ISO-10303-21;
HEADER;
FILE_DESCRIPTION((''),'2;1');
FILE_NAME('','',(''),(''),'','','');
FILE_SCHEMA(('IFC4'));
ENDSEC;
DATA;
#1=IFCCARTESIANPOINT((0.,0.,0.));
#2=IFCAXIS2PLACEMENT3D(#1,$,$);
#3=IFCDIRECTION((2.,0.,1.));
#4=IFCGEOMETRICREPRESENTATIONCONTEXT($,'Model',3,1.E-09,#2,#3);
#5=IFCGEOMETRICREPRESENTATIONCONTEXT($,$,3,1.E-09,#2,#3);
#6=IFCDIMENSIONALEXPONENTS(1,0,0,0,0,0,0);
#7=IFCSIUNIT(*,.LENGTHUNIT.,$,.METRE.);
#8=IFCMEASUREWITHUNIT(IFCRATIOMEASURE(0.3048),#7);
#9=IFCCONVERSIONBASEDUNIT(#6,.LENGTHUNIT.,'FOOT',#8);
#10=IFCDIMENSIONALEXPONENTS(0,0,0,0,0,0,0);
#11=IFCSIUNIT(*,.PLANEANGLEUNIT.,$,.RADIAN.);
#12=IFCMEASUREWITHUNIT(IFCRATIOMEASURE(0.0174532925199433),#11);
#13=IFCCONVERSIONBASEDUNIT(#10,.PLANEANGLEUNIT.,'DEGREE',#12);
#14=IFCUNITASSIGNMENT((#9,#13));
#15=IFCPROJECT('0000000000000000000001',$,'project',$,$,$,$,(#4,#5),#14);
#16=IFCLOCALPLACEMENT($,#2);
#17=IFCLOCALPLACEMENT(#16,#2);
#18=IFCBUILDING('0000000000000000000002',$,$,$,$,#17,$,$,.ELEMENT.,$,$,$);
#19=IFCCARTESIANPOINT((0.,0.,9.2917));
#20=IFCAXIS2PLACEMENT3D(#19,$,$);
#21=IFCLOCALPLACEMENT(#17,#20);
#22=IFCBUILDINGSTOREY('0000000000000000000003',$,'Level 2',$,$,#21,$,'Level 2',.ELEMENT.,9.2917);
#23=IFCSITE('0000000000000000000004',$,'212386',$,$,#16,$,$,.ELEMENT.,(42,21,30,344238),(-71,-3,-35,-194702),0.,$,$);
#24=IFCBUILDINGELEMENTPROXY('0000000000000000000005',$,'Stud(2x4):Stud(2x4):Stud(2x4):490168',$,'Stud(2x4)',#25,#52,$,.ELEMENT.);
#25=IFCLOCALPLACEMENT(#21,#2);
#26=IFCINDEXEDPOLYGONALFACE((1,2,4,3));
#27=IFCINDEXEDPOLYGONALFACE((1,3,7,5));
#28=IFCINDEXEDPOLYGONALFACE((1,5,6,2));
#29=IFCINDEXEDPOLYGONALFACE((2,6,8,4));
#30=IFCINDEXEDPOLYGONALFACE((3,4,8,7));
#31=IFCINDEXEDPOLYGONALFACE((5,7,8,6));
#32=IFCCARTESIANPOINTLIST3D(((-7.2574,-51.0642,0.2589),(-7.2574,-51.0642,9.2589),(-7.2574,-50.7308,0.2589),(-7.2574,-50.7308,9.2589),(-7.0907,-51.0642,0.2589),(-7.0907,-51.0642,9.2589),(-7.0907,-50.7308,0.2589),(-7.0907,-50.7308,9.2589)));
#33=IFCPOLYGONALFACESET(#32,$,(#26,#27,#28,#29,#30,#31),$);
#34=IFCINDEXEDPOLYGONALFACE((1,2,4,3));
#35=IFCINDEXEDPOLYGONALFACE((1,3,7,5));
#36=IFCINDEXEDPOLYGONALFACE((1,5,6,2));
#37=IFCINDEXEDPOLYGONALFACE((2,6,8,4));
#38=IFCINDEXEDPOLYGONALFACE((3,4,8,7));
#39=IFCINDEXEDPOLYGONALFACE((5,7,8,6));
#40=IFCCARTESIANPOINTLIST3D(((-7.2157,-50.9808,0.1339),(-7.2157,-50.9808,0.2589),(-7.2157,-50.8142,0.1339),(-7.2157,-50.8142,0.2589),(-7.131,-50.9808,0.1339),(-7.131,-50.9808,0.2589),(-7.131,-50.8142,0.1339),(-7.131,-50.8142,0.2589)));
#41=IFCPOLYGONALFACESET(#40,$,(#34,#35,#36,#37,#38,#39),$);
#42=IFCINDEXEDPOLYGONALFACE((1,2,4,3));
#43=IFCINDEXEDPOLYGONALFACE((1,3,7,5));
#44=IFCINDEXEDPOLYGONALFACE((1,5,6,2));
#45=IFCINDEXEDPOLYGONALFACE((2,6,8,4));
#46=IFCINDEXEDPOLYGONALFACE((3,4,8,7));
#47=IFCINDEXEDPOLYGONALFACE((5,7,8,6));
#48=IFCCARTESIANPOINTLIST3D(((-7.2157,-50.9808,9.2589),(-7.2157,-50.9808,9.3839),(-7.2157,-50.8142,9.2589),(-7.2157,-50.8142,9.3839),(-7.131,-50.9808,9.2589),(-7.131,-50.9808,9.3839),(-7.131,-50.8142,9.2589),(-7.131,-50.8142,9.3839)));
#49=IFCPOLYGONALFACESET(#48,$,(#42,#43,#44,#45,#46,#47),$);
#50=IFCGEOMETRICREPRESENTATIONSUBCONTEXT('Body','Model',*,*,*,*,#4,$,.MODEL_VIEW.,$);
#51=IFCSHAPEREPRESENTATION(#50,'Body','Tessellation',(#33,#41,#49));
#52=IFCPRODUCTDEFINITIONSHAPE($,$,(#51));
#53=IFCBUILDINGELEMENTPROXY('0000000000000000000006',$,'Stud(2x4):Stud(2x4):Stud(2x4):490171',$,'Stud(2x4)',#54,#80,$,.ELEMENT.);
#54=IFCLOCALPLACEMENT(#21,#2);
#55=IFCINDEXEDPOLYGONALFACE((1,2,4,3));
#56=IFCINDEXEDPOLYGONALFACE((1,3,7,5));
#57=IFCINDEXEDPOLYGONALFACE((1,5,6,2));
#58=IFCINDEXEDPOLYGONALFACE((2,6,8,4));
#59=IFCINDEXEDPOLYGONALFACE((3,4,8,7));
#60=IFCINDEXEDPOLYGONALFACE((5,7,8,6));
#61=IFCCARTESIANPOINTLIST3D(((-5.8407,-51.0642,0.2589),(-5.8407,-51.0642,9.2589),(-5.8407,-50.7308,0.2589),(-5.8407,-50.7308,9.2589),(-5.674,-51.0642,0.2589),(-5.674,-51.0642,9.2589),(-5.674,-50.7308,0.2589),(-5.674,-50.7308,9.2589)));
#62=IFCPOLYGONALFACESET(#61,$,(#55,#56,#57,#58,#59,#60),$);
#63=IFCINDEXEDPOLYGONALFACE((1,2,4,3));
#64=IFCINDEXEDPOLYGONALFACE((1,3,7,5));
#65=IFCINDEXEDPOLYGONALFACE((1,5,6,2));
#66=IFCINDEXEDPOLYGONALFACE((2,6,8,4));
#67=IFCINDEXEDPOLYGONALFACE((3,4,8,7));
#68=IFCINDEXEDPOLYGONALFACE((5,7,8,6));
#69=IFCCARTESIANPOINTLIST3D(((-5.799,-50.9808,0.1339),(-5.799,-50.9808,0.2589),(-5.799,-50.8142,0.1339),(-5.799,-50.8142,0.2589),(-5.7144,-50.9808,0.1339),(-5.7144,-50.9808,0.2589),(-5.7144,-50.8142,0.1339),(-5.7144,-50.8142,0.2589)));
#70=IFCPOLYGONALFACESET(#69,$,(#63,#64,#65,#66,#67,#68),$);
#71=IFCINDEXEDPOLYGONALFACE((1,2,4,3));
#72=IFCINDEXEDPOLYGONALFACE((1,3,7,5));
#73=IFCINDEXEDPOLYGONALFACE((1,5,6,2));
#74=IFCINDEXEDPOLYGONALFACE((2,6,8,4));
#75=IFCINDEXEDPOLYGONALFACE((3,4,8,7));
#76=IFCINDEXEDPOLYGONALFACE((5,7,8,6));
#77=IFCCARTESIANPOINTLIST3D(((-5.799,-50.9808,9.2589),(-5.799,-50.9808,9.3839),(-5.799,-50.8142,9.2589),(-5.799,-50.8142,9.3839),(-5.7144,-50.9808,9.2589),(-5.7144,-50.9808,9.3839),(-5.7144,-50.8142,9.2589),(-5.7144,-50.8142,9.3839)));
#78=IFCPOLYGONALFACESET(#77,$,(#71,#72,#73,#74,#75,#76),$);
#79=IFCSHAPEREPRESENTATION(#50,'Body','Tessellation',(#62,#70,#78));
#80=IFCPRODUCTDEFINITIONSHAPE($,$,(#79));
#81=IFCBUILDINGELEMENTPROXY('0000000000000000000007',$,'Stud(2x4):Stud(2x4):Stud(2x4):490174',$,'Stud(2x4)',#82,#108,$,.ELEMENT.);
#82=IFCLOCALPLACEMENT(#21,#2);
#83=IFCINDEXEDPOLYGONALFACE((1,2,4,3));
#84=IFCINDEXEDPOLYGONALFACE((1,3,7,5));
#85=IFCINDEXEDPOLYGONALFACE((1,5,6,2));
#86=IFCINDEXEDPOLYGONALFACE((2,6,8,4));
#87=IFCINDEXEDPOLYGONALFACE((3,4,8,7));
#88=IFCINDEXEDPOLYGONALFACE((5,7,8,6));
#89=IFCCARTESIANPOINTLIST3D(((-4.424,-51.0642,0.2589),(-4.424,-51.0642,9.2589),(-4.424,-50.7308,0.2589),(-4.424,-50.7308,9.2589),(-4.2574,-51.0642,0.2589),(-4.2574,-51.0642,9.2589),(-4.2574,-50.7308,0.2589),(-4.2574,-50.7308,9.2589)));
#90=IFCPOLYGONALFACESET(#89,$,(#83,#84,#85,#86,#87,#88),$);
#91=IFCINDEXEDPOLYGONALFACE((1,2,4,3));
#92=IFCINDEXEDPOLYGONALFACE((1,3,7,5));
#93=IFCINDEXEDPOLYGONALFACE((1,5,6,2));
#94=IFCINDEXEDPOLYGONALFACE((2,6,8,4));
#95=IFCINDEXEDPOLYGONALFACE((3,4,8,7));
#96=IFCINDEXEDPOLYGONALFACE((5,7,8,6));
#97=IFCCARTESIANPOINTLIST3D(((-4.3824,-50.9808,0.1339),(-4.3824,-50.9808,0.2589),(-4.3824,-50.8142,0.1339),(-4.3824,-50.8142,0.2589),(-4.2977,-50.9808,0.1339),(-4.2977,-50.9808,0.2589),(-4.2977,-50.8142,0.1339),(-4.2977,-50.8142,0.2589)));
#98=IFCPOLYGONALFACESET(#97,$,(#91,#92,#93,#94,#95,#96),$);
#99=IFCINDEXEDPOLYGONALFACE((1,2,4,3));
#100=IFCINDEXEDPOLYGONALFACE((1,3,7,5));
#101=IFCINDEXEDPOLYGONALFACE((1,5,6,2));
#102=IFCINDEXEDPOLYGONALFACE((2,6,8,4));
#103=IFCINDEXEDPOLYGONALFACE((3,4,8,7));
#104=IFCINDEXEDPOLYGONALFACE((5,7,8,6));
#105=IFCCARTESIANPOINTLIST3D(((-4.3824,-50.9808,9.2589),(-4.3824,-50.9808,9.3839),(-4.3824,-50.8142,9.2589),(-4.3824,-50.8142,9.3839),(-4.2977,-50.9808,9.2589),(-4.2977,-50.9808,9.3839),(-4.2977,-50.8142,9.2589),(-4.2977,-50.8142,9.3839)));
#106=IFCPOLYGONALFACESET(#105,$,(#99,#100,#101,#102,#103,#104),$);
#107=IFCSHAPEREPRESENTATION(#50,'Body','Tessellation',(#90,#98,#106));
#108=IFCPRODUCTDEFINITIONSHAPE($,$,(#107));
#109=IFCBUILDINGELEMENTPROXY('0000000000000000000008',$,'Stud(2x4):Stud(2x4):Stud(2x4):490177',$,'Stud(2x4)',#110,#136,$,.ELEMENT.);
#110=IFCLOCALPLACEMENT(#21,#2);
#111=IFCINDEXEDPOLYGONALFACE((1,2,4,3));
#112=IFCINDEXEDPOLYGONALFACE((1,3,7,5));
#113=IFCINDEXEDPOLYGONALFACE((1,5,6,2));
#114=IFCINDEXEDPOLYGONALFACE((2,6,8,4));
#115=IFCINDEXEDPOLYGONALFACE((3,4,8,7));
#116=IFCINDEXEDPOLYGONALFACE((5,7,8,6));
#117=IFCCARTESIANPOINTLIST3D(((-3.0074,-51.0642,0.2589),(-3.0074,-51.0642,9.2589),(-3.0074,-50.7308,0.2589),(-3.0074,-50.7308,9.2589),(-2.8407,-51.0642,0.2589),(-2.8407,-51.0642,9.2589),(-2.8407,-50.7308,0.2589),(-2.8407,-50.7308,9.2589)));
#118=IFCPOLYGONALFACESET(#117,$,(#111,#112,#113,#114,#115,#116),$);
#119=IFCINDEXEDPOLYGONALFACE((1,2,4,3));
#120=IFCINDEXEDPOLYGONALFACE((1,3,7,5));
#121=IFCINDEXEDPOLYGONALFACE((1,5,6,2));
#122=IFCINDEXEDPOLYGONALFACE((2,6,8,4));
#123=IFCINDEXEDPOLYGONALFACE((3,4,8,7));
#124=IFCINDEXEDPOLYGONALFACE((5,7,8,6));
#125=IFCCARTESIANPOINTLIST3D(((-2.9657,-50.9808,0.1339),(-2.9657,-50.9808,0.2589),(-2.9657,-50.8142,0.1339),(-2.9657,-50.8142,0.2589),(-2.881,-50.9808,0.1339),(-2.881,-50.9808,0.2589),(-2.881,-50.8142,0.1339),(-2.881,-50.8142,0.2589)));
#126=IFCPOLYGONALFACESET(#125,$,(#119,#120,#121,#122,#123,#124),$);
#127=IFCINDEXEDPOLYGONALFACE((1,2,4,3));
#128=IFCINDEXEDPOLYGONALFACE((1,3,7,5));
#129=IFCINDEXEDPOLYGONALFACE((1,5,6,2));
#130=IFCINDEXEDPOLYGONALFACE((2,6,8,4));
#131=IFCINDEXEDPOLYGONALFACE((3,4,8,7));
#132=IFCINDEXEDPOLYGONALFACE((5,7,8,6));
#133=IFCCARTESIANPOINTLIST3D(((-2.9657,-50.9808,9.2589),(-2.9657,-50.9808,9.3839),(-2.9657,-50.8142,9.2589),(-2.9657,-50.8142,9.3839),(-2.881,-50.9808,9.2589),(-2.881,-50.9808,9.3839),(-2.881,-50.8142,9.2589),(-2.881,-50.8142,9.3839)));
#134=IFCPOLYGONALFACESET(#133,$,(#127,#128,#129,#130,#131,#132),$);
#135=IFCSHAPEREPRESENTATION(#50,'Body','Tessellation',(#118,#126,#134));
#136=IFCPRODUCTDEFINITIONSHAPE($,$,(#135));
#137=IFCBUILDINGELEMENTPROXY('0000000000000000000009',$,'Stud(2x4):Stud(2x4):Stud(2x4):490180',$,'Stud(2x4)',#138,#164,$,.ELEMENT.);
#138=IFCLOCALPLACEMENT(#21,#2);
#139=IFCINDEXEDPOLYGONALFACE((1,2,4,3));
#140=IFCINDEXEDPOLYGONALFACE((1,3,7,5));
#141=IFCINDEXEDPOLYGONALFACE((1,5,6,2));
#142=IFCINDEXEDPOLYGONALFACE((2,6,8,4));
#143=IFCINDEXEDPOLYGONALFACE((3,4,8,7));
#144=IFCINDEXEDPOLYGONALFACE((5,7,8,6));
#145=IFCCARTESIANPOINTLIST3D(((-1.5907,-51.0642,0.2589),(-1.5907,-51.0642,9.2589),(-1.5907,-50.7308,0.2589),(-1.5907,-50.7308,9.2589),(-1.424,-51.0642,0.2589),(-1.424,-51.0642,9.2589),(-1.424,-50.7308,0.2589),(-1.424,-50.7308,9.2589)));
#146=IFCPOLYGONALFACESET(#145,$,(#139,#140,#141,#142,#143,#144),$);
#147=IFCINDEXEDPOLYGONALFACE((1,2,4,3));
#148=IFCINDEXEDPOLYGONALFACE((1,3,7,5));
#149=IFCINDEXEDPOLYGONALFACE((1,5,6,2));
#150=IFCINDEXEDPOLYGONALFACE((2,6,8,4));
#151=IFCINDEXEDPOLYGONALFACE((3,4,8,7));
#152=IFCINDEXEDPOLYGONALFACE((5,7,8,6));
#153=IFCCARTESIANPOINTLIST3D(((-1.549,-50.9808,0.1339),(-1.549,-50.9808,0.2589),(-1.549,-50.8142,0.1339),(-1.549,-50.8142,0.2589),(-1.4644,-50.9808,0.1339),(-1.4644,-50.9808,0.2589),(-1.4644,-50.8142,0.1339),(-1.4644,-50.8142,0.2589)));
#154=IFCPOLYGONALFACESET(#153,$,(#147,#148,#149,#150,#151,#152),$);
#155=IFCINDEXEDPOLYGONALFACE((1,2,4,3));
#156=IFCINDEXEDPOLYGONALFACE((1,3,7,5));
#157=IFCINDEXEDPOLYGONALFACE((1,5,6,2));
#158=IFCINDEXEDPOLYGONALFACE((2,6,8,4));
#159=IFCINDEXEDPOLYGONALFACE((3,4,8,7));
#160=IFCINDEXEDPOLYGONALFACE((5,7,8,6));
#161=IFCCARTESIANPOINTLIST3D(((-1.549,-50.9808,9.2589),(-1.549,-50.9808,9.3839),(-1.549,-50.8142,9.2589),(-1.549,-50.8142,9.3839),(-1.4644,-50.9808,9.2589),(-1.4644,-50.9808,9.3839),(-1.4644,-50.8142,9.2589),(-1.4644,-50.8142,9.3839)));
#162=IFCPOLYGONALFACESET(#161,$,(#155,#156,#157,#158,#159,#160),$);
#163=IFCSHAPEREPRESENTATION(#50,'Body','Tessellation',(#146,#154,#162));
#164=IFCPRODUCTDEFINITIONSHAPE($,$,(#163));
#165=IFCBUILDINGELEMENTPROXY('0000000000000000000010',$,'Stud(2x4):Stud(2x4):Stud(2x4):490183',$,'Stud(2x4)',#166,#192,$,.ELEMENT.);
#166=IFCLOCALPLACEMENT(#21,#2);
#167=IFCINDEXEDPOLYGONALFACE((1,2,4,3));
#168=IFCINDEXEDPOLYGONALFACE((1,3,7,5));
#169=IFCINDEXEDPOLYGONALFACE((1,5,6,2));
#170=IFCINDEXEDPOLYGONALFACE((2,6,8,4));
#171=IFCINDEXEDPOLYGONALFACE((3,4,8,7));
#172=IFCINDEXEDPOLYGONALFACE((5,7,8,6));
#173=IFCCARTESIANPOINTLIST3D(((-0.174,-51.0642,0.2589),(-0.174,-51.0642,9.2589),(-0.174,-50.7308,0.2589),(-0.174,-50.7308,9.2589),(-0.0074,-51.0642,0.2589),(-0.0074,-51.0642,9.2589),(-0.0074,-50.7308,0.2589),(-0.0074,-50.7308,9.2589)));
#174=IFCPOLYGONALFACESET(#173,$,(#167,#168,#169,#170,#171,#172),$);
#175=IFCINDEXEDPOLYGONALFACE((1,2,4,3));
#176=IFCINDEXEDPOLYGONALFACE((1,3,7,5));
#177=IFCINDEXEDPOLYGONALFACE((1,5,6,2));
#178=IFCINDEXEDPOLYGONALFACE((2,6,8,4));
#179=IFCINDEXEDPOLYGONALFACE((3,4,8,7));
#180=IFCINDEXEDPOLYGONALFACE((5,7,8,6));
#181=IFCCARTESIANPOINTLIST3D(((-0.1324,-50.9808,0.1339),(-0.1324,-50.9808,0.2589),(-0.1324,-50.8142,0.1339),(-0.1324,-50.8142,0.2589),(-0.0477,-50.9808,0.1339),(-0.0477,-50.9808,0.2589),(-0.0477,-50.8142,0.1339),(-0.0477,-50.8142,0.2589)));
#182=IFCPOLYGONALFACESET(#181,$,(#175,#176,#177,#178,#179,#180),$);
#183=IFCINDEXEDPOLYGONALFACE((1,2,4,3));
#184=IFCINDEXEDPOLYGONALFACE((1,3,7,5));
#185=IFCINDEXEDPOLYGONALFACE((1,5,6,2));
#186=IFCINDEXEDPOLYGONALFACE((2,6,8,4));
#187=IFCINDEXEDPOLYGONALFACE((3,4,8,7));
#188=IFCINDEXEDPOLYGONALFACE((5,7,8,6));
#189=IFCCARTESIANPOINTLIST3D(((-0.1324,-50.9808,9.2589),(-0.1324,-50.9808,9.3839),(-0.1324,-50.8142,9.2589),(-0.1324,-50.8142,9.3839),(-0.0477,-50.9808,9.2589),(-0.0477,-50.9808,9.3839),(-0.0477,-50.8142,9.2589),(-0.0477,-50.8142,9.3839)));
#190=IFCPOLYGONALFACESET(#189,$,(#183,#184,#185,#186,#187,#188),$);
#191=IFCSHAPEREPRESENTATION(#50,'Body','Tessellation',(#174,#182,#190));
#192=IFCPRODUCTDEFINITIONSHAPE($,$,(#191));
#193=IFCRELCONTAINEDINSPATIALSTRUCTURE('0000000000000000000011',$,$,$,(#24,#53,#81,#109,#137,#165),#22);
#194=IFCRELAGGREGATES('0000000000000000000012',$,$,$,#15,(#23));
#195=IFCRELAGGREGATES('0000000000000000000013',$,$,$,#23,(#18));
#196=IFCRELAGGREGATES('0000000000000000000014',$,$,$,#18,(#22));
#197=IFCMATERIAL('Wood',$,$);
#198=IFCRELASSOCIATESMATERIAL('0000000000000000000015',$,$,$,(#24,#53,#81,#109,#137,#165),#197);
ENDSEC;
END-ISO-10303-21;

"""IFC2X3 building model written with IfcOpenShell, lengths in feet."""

from ifc_helpers import new_model, entity, si_unit, converted_unit, direction, frame, frame_2d, origin, place, context, subcontext, project, spatial, rectangle, extrude, source, transform, mapped, material, element, save


model = new_model("IFC2X3")

# Units and contexts
model_context = context("Model", 3, precision=1e-09, world=origin(), true_north=direction((2.0, 0.0, 1.0)))
context_of_model = context(None, 3, precision=1e-09, world=origin(), true_north=direction((2.0, 0.0, 1.0)))
body_context = subcontext(model_context, "Body", "Model", "MODEL_VIEW")
ifc_project = project(units=[converted_unit("LENGTHUNIT", "FOOT", entity("IfcRatioMeasure", 0.3048), si_unit("LENGTHUNIT", "METRE"), dimensions=[1, 0, 0, 0, 0, 0, 0]), converted_unit("PLANEANGLEUNIT", "DEGREE", entity("IfcRatioMeasure", 0.0174532925199433), si_unit("PLANEANGLEUNIT", "RADIAN"), dimensions=[0, 0, 0, 0, 0, 0, 0])], contexts=[model_context, context_of_model])

# Site, building, storey
site_placement = place(None, origin())
site = spatial("IfcSite", under=ifc_project, at=site_placement, Name="212386", CompositionType="ELEMENT", RefLatitude=(42, 21, 30, 344238), RefLongitude=(-71, -3, -35, -194702), RefElevation=0.0)
building_placement = place(site_placement, origin())
building = spatial("IfcBuilding", under=site, at=building_placement, CompositionType="ELEMENT")
storey_placement = place(building_placement, frame((0.0, 0.0, 9.2917)))
storey = spatial("IfcBuildingStorey", under=building, at=storey_placement, Name="Level 2", LongName="Level 2", CompositionType="ELEMENT", Elevation=9.2917)

# Building element proxies
ifc_material = material(Name="Wood")
shared_shape_1 = source(origin(), body_context, "Body", "SweptSolid", [
    extrude(rectangle(XDim=0.3333, YDim=0.1667, at=frame_2d((0.0, 0.0), x_axis=(1.0, 0.0))), frame((-7.174, -50.8975, 9.5506), z_axis=(0.0, 0.0, 1.0), x_axis=(0.0, -1.0, 0.0)), (0.0, 0.0, 1.0), 9.0),
    extrude(rectangle(XDim=0.1667, YDim=0.0847, at=frame_2d((0.0, 0.0), x_axis=(1.0, 0.0))), frame((-7.1734, -50.8975, 9.4256), z_axis=(0.0, 0.0, 1.0), x_axis=(0.0, -1.0, 0.0)), (0.0, 0.0, 1.0), 0.125),
    extrude(rectangle(XDim=0.0847, YDim=0.1667, at=frame_2d((0.0, 0.0), x_axis=(1.0, 0.0))), frame((-7.1734, -50.8975, 18.5506)), (0.0, 0.0, 1.0), 0.125),
])
proxy_1_placement = place(storey_placement, frame((0.0, 0.0, -9.2917)))
element("IfcBuildingElementProxy", 1, at=proxy_1_placement, inside=storey, material=ifc_material, Name="Stud(2x4):Stud(2x4):Stud(2x4):490168", ObjectType="Stud(2x4)", CompositionType="ELEMENT", context=body_context, shape_type="MappedRepresentation", body=[
    mapped(shared_shape_1, transform((0.0, 0.0, 0.0), scale=1.0)),
])
shared_shape_2 = source(origin(), body_context, "Body", "SweptSolid", [
    extrude(rectangle(XDim=0.3333, YDim=0.1667, at=frame_2d((0.0, 0.0), x_axis=(1.0, 0.0))), frame((-5.7574, -50.8975, 9.5506), z_axis=(0.0, 0.0, 1.0), x_axis=(0.0, -1.0, 0.0)), (0.0, 0.0, 1.0), 9.0),
    extrude(rectangle(XDim=0.1667, YDim=0.0847, at=frame_2d((0.0, 0.0), x_axis=(1.0, 0.0))), frame((-5.7567, -50.8975, 9.4256), z_axis=(0.0, 0.0, 1.0), x_axis=(0.0, -1.0, 0.0)), (0.0, 0.0, 1.0), 0.125),
    extrude(rectangle(XDim=0.0847, YDim=0.1667, at=frame_2d((0.0, 0.0), x_axis=(1.0, 0.0))), frame((-5.7567, -50.8975, 18.5506)), (0.0, 0.0, 1.0), 0.125),
])
proxy_2_placement = place(storey_placement, frame((0.0, 0.0, -9.2917)))
element("IfcBuildingElementProxy", 2, at=proxy_2_placement, inside=storey, material=ifc_material, Name="Stud(2x4):Stud(2x4):Stud(2x4):490171", ObjectType="Stud(2x4)", CompositionType="ELEMENT", context=body_context, shape_type="MappedRepresentation", body=[
    mapped(shared_shape_2, transform((0.0, 0.0, 0.0), scale=1.0)),
])
shared_shape_3 = source(origin(), body_context, "Body", "SweptSolid", [
    extrude(rectangle(XDim=0.3333, YDim=0.1667, at=frame_2d((0.0, 0.0), x_axis=(1.0, 0.0))), frame((-4.3407, -50.8975, 9.5506), z_axis=(0.0, 0.0, 1.0), x_axis=(0.0, -1.0, 0.0)), (0.0, 0.0, 1.0), 9.0),
    extrude(rectangle(XDim=0.1667, YDim=0.0847, at=frame_2d((0.0, 0.0), x_axis=(1.0, 0.0))), frame((-4.34, -50.8975, 9.4256), z_axis=(0.0, 0.0, 1.0), x_axis=(0.0, -1.0, 0.0)), (0.0, 0.0, 1.0), 0.125),
    extrude(rectangle(XDim=0.0847, YDim=0.1667, at=frame_2d((0.0, 0.0), x_axis=(1.0, 0.0))), frame((-4.34, -50.8975, 18.5506)), (0.0, 0.0, 1.0), 0.125),
])
proxy_3_placement = place(storey_placement, frame((0.0, 0.0, -9.2917)))
element("IfcBuildingElementProxy", 3, at=proxy_3_placement, inside=storey, material=ifc_material, Name="Stud(2x4):Stud(2x4):Stud(2x4):490174", ObjectType="Stud(2x4)", CompositionType="ELEMENT", context=body_context, shape_type="MappedRepresentation", body=[
    mapped(shared_shape_3, transform((0.0, 0.0, 0.0), scale=1.0)),
])
shared_shape_4 = source(origin(), body_context, "Body", "SweptSolid", [
    extrude(rectangle(XDim=0.3333, YDim=0.1667, at=frame_2d((0.0, 0.0), x_axis=(1.0, 0.0))), frame((-2.924, -50.8975, 9.5506), z_axis=(0.0, 0.0, 1.0), x_axis=(0.0, -1.0, 0.0)), (0.0, 0.0, 1.0), 9.0),
    extrude(rectangle(XDim=0.1667, YDim=0.0847, at=frame_2d((0.0, 0.0), x_axis=(1.0, 0.0))), frame((-2.9234, -50.8975, 9.4256), z_axis=(0.0, 0.0, 1.0), x_axis=(0.0, -1.0, 0.0)), (0.0, 0.0, 1.0), 0.125),
    extrude(rectangle(XDim=0.0847, YDim=0.1667, at=frame_2d((0.0, 0.0), x_axis=(1.0, 0.0))), frame((-2.9234, -50.8975, 18.5506)), (0.0, 0.0, 1.0), 0.125),
])
proxy_4_placement = place(storey_placement, frame((0.0, 0.0, -9.2917)))
element("IfcBuildingElementProxy", 4, at=proxy_4_placement, inside=storey, material=ifc_material, Name="Stud(2x4):Stud(2x4):Stud(2x4):490177", ObjectType="Stud(2x4)", CompositionType="ELEMENT", context=body_context, shape_type="MappedRepresentation", body=[
    mapped(shared_shape_4, transform((0.0, 0.0, 0.0), scale=1.0)),
])
shared_shape_5 = source(origin(), body_context, "Body", "SweptSolid", [
    extrude(rectangle(XDim=0.3333, YDim=0.1667, at=frame_2d((0.0, 0.0), x_axis=(1.0, 0.0))), frame((-1.5074, -50.8975, 9.5506), z_axis=(0.0, 0.0, 1.0), x_axis=(0.0, -1.0, 0.0)), (0.0, 0.0, 1.0), 9.0),
    extrude(rectangle(XDim=0.1667, YDim=0.0847, at=frame_2d((0.0, 0.0), x_axis=(1.0, 0.0))), frame((-1.5067, -50.8975, 9.4256), z_axis=(0.0, 0.0, 1.0), x_axis=(0.0, -1.0, 0.0)), (0.0, 0.0, 1.0), 0.125),
    extrude(rectangle(XDim=0.0847, YDim=0.1667, at=frame_2d((0.0, 0.0), x_axis=(1.0, 0.0))), frame((-1.5067, -50.8975, 18.5506)), (0.0, 0.0, 1.0), 0.125),
])
proxy_5_placement = place(storey_placement, frame((0.0, 0.0, -9.2917)))
element("IfcBuildingElementProxy", 5, at=proxy_5_placement, inside=storey, material=ifc_material, Name="Stud(2x4):Stud(2x4):Stud(2x4):490180", ObjectType="Stud(2x4)", CompositionType="ELEMENT", context=body_context, shape_type="MappedRepresentation", body=[
    mapped(shared_shape_5, transform((0.0, 0.0, 0.0), scale=1.0)),
])
shared_shape_6 = source(origin(), body_context, "Body", "SweptSolid", [
    extrude(rectangle(XDim=0.3333, YDim=0.1667, at=frame_2d((0.0, 0.0), x_axis=(1.0, 0.0))), frame((-0.0907, -50.8975, 9.5506), z_axis=(0.0, 0.0, 1.0), x_axis=(0.0, -1.0, 0.0)), (0.0, 0.0, 1.0), 9.0),
    extrude(rectangle(XDim=0.1667, YDim=0.0847, at=frame_2d((0.0, 0.0), x_axis=(1.0, 0.0))), frame((-0.09, -50.8975, 9.4256), z_axis=(0.0, 0.0, 1.0), x_axis=(0.0, -1.0, 0.0)), (0.0, 0.0, 1.0), 0.125),
    extrude(rectangle(XDim=0.0847, YDim=0.1667, at=frame_2d((0.0, 0.0), x_axis=(1.0, 0.0))), frame((-0.09, -50.8975, 18.5506)), (0.0, 0.0, 1.0), 0.125),
])
proxy_6_placement = place(storey_placement, frame((0.0, 0.0, -9.2917)))
element("IfcBuildingElementProxy", 6, at=proxy_6_placement, inside=storey, material=ifc_material, Name="Stud(2x4):Stud(2x4):Stud(2x4):490183", ObjectType="Stud(2x4)", CompositionType="ELEMENT", context=body_context, shape_type="MappedRepresentation", body=[
    mapped(shared_shape_6, transform((0.0, 0.0, 0.0), scale=1.0)),
])

save(model, "model.ifc")
